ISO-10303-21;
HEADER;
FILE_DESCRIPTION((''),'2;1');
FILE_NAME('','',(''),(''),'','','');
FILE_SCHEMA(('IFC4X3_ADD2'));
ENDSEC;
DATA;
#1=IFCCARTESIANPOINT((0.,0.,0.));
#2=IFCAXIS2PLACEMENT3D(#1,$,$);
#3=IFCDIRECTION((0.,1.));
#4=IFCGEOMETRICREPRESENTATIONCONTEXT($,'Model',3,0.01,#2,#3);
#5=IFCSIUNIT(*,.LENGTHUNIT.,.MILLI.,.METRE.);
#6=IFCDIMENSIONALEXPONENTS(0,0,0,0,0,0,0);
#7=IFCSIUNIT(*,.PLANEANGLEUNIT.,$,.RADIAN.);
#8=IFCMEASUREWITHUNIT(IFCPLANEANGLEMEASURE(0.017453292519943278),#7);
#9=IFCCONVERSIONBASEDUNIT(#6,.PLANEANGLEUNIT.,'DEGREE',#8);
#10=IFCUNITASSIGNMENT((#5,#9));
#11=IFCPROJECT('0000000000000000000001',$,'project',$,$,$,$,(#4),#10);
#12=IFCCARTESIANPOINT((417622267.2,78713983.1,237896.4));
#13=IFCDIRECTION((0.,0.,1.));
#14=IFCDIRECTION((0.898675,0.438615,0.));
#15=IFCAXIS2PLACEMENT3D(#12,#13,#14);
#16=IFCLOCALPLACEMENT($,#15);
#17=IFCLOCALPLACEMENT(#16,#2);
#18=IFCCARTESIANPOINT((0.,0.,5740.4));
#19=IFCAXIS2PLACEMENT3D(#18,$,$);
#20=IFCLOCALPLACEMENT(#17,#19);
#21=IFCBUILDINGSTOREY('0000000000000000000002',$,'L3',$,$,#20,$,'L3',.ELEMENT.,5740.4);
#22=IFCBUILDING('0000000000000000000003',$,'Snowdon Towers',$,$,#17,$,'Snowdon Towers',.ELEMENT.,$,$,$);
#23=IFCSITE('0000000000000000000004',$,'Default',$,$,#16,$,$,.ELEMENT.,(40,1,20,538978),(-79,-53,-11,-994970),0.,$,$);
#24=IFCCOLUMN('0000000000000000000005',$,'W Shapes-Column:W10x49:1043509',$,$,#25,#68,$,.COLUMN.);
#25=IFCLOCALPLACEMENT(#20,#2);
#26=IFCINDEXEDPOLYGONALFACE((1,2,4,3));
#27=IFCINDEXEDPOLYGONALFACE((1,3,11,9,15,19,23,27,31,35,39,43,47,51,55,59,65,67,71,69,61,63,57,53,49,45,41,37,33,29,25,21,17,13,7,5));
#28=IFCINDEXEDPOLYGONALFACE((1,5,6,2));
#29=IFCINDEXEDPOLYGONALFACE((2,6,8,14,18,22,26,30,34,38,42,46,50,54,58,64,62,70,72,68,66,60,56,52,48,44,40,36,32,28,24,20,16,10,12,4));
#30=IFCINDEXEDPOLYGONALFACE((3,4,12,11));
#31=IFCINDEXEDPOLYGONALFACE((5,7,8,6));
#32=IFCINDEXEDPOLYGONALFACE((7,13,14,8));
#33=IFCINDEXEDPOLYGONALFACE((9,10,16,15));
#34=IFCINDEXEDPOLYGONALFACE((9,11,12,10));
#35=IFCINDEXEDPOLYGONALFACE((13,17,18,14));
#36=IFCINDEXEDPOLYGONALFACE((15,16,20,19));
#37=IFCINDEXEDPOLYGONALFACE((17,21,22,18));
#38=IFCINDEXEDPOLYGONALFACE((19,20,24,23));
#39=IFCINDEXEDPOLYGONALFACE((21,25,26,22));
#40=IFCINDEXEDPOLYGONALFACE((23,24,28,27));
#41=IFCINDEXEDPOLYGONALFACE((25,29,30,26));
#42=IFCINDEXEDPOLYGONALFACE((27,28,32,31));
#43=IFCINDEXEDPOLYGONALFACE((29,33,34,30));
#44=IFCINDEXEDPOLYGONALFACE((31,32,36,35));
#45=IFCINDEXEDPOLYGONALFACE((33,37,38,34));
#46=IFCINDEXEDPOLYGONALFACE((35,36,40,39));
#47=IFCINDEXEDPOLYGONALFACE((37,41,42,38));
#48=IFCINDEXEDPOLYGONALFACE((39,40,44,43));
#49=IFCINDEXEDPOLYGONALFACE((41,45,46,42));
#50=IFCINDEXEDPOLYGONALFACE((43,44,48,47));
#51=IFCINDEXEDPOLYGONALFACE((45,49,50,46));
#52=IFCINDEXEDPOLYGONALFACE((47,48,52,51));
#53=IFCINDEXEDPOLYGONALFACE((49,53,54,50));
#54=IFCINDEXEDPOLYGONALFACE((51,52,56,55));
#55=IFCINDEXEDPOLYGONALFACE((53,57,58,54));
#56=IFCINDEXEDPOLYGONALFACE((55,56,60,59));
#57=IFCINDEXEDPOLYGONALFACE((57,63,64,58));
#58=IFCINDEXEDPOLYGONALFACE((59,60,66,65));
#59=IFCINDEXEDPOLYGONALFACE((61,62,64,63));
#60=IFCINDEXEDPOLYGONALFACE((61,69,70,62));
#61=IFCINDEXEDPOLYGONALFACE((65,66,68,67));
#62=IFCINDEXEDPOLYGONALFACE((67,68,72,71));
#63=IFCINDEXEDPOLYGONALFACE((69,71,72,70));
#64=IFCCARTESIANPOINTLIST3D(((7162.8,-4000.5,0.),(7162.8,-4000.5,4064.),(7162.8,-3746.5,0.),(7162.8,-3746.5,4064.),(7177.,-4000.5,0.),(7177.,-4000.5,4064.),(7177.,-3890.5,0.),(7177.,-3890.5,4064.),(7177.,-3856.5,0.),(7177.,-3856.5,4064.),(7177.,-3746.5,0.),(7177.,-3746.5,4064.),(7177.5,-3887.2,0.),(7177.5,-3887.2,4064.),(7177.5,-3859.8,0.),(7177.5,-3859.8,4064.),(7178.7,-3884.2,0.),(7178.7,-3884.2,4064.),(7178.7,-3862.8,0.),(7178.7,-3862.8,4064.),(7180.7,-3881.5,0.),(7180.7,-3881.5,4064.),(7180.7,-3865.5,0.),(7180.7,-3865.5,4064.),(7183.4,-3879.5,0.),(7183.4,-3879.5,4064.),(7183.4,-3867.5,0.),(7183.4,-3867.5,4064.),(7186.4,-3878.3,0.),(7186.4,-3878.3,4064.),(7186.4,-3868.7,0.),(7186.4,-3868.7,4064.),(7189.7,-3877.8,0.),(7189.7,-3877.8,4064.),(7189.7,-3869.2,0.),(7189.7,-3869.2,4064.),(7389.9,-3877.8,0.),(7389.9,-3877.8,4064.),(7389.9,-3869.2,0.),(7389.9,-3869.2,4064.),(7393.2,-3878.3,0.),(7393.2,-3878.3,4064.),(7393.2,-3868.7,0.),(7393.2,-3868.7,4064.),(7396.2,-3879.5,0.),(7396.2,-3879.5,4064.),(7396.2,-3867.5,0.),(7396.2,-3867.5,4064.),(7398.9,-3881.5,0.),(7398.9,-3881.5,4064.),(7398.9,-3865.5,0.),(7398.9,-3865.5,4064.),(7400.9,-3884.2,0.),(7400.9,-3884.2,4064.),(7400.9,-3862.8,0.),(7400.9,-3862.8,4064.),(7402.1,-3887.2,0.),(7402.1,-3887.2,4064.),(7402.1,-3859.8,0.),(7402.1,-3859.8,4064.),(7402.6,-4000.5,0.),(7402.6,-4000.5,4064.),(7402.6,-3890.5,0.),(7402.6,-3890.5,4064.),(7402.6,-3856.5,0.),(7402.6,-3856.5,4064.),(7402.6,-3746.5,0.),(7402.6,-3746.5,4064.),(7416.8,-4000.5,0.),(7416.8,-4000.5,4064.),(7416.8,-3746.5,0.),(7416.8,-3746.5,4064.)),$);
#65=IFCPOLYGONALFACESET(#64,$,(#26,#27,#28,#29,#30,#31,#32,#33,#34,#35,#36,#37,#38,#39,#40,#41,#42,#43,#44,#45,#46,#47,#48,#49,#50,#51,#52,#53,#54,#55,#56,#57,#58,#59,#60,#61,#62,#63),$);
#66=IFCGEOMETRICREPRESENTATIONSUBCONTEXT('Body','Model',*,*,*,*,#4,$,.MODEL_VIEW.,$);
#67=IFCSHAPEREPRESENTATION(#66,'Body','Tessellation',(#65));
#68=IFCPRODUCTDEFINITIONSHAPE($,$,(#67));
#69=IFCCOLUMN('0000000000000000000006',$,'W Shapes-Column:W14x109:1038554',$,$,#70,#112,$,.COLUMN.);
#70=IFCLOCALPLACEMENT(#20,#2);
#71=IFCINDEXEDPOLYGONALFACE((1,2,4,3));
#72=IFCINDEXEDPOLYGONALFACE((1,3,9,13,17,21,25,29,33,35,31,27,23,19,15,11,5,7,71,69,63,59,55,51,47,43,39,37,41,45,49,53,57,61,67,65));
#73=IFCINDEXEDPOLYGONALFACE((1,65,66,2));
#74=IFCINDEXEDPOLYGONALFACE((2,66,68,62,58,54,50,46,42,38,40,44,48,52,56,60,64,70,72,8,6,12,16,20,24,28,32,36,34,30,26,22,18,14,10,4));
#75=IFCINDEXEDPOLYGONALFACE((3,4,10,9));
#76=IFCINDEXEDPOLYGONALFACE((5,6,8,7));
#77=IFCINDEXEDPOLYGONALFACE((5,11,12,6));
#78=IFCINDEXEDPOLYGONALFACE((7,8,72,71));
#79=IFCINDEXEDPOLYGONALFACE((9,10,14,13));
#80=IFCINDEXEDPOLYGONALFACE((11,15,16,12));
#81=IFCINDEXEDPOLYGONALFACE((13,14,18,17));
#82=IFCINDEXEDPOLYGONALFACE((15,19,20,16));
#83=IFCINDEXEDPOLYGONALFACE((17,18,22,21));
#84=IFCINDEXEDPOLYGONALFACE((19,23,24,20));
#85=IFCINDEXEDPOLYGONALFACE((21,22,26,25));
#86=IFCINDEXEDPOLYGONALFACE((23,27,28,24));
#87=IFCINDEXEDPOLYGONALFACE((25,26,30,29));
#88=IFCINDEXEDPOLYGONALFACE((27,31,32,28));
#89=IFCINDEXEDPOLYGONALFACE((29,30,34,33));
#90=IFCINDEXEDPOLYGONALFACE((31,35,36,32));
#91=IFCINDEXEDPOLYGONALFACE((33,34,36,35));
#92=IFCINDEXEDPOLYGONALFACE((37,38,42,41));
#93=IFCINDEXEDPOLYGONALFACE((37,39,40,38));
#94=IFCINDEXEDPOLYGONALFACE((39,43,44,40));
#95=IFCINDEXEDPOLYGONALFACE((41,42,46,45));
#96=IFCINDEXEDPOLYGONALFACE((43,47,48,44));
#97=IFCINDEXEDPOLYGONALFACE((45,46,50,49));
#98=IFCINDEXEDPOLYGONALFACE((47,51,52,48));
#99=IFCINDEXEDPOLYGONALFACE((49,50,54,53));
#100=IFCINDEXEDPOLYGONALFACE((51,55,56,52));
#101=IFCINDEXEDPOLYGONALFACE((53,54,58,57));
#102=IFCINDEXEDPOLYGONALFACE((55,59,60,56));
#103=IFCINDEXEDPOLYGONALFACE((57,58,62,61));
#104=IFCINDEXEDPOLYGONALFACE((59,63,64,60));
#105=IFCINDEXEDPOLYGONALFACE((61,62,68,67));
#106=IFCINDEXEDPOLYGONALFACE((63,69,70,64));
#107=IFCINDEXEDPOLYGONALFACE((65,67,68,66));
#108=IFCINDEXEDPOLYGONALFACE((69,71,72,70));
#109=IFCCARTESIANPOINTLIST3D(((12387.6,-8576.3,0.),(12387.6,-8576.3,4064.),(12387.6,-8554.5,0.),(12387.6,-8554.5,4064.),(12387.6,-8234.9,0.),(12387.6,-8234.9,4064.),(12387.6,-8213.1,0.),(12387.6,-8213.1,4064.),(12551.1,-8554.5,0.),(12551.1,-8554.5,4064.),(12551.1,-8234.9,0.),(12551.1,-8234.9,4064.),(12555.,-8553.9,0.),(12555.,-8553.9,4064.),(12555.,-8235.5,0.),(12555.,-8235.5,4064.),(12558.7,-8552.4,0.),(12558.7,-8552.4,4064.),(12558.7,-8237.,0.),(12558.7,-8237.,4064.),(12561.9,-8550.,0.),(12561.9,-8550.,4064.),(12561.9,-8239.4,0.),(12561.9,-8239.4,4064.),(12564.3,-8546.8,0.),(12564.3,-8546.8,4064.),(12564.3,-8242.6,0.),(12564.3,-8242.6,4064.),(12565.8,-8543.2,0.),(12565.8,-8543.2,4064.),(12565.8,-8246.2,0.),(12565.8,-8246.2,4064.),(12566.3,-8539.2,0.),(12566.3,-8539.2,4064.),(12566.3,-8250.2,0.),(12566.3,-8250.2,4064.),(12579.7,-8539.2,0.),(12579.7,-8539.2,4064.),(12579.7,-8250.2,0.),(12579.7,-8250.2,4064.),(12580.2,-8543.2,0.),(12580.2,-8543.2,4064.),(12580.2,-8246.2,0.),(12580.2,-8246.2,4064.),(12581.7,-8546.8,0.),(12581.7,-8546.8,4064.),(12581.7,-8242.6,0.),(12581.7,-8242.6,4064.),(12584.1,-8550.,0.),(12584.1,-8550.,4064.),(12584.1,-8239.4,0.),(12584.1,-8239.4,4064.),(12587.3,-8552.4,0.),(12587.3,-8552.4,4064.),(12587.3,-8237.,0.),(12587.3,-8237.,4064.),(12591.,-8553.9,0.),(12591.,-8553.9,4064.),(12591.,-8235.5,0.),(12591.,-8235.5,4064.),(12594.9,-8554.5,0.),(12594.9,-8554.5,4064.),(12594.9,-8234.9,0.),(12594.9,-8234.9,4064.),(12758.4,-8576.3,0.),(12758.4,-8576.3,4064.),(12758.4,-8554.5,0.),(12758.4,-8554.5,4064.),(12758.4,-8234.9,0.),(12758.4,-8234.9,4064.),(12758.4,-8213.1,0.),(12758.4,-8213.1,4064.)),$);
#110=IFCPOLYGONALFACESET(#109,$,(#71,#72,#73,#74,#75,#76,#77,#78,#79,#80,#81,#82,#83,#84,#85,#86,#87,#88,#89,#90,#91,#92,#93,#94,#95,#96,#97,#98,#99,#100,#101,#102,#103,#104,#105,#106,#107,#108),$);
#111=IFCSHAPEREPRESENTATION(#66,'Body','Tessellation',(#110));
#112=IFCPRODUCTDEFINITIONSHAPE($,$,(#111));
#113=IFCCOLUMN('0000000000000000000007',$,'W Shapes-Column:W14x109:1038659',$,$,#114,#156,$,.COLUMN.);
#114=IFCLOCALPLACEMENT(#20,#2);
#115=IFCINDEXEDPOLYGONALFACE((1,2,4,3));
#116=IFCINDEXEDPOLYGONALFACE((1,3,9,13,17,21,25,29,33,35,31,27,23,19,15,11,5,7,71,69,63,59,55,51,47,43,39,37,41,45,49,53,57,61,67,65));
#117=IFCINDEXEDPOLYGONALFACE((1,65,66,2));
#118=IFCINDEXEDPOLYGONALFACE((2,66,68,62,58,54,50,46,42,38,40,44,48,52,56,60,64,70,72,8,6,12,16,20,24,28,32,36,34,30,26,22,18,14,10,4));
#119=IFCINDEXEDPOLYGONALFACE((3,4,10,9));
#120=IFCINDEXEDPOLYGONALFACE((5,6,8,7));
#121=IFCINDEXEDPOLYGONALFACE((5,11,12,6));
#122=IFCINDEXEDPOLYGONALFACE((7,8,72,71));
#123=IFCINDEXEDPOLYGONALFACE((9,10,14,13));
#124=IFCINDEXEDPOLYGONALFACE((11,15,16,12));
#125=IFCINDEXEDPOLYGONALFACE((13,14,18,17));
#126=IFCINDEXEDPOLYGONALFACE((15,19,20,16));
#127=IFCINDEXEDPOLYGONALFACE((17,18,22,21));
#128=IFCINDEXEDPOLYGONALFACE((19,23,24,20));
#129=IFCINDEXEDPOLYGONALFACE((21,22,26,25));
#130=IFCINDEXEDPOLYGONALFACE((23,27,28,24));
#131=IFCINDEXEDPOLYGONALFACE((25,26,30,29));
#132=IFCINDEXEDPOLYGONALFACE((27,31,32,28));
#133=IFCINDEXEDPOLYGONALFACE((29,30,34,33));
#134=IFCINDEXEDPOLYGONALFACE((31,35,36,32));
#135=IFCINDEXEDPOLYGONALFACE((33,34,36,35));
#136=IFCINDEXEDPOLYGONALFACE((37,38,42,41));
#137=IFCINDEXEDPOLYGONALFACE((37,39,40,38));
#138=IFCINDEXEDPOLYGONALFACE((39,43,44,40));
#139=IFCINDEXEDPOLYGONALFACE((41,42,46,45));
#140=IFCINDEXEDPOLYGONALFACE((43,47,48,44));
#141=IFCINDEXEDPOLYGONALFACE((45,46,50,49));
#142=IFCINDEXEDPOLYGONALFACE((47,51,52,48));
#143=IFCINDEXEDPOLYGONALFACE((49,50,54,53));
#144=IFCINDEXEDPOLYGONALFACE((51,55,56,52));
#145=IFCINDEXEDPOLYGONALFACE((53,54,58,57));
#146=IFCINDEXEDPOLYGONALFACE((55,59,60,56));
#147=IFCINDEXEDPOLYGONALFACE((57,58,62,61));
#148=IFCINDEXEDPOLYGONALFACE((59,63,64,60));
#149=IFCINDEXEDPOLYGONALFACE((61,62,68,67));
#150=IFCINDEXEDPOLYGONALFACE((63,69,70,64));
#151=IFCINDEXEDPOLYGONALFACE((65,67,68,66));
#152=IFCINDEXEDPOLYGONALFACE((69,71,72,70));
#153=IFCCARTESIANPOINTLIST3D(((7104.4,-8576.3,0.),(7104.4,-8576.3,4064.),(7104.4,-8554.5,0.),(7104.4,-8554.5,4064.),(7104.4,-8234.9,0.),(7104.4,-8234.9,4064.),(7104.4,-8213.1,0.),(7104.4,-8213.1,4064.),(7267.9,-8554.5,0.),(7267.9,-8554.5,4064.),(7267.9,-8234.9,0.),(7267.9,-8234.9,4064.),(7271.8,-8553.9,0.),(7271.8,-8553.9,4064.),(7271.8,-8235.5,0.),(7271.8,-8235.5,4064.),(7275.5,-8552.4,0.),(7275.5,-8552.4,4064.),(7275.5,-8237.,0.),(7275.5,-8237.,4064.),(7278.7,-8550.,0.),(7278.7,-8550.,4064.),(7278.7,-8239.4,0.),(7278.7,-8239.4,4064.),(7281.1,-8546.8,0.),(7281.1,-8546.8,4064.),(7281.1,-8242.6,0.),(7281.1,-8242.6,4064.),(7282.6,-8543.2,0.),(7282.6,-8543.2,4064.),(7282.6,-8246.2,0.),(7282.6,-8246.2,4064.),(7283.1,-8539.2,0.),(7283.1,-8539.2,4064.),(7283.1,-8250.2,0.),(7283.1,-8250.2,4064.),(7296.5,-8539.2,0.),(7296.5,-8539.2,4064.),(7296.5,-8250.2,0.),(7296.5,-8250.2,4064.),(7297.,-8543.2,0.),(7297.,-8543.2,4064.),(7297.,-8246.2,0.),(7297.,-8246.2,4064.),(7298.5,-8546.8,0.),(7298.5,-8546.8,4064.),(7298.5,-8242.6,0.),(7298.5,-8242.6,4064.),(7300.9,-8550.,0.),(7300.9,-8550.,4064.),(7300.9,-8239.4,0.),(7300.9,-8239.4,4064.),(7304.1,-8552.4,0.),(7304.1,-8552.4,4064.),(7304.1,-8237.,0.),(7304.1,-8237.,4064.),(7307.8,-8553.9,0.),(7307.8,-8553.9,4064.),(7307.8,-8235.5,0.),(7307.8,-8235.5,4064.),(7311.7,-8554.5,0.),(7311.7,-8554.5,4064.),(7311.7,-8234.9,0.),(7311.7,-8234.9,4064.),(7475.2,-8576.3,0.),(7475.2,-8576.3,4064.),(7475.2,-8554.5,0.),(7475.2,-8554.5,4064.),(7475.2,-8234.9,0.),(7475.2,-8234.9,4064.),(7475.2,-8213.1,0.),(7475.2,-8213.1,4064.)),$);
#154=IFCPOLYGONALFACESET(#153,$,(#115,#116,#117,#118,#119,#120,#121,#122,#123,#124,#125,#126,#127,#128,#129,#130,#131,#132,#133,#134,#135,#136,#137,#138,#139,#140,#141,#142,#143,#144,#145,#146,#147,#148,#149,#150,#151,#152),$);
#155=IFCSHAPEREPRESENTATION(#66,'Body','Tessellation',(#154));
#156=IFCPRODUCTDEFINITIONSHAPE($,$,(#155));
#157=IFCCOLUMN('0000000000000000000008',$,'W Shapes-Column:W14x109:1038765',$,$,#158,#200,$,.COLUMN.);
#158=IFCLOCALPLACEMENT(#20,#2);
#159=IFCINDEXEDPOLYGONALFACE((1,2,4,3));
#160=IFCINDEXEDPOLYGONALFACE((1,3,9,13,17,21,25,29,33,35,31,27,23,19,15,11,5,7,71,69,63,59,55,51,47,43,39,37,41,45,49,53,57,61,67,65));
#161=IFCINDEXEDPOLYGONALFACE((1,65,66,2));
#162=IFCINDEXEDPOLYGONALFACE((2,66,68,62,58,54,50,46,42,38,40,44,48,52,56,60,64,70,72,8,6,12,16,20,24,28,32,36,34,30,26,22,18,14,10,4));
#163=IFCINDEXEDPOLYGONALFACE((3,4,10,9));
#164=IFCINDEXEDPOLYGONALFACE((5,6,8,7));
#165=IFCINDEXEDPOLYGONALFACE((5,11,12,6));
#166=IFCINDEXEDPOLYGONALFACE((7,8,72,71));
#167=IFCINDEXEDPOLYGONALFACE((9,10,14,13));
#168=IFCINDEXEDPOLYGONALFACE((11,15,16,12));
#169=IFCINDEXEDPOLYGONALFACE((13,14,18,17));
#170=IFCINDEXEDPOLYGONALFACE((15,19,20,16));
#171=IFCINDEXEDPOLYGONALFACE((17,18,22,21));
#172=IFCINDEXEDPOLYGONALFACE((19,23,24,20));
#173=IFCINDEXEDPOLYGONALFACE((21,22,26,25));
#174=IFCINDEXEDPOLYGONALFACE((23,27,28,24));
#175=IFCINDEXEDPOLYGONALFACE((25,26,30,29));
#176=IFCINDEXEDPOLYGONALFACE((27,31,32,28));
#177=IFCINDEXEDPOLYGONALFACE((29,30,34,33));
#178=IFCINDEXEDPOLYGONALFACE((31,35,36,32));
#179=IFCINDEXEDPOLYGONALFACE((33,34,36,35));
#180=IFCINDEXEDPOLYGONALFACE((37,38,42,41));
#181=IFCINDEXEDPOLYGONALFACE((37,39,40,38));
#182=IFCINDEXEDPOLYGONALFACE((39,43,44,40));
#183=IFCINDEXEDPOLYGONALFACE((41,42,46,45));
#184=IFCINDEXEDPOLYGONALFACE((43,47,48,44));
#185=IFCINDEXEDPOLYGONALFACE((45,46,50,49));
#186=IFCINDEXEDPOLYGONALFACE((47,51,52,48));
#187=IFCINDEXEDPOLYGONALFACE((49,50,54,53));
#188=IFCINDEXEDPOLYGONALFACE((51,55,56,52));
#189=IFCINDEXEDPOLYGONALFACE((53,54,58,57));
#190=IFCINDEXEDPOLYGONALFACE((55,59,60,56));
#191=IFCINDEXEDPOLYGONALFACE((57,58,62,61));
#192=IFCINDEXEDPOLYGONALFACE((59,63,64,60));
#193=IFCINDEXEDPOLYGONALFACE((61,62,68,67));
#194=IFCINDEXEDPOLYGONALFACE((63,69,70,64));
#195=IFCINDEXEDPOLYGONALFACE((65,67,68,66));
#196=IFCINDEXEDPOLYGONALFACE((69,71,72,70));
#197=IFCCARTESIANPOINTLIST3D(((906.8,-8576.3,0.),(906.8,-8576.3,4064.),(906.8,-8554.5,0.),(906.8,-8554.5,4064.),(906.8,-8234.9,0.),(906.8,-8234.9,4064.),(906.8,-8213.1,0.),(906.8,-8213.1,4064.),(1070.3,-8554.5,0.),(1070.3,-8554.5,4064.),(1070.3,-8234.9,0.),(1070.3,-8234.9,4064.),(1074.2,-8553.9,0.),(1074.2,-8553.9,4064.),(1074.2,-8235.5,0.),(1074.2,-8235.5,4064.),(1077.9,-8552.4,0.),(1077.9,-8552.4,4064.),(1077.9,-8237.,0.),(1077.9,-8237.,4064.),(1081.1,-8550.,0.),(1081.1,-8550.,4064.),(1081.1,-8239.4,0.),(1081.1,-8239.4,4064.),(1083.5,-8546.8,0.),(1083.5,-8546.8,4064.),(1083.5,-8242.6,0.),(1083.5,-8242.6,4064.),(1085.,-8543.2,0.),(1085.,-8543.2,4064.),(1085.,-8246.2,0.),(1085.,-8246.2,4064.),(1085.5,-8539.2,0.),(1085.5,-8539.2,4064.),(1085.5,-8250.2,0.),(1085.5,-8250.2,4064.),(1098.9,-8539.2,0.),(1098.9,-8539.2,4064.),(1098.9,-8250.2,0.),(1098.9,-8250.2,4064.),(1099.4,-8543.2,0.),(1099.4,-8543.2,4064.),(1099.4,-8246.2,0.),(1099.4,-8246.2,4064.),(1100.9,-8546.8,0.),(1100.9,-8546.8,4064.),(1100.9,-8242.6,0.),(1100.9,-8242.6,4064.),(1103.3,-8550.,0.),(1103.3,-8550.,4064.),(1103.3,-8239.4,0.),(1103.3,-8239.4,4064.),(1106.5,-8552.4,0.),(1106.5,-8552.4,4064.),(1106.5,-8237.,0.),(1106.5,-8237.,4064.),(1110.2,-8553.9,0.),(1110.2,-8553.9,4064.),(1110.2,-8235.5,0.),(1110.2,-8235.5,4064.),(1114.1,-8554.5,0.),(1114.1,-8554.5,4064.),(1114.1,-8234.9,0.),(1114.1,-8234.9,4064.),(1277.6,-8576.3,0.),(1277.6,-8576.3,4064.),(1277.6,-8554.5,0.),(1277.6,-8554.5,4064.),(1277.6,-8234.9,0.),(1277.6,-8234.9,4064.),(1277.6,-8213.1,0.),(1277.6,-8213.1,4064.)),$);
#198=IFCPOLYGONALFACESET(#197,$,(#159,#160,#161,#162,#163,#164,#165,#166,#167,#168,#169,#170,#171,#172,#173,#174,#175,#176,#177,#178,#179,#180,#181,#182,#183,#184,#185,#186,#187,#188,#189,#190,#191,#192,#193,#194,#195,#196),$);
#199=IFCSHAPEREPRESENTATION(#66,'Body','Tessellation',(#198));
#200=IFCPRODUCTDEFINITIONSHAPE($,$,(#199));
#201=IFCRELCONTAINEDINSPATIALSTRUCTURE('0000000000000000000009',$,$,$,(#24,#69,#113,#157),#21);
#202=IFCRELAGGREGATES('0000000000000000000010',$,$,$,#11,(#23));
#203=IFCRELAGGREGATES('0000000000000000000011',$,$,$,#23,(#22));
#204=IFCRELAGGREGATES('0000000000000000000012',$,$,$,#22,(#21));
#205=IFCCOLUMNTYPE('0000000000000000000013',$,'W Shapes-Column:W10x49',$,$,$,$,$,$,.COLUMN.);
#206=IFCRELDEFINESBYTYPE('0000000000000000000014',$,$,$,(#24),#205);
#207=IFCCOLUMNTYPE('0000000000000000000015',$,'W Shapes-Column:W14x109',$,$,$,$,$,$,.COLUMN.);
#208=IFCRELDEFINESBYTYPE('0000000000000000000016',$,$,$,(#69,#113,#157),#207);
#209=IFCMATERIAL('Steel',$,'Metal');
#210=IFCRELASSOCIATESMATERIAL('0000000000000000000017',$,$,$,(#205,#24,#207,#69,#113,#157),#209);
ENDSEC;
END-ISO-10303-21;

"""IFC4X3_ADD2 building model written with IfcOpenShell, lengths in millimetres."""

from ifc_helpers import new_model, entity, si_unit, converted_unit, direction, frame, frame_2d, origin, place, context, subcontext, project, spatial, i_section, extrude, source, transform, mapped, material, material_profile, profile_set, profile_usage, type_object, type_shapes, element, save


model = new_model("IFC4X3_ADD2")

# Units and contexts
model_context = context("Model", 3, precision=0.01, world=origin(), true_north=direction((0.0, 1.0)))
body_context = subcontext(model_context, "Body", "Model", "MODEL_VIEW")
ifc_project = project(units=[si_unit("LENGTHUNIT", "METRE", prefix="MILLI"), converted_unit("PLANEANGLEUNIT", "DEGREE", entity("IfcPlaneAngleMeasure", 0.017453292519943278), si_unit("PLANEANGLEUNIT", "RADIAN"), dimensions=[0, 0, 0, 0, 0, 0, 0])], contexts=[model_context])

# Site, building, storey
site_placement = place(None, frame((417622267.2, 78713983.1, 237896.4), z_axis=(0.0, 0.0, 1.0), x_axis=(0.898675, 0.438615, 0.0)))
site = spatial("IfcSite", under=ifc_project, at=site_placement, Name="Default", CompositionType="ELEMENT", RefLatitude=(40, 1, 20, 538978), RefLongitude=(-79, -53, -11, -994970), RefElevation=0.0)
building_placement = place(site_placement, origin())
building = spatial("IfcBuilding", under=site, at=building_placement, Name="Snowdon Towers", LongName="Snowdon Towers", CompositionType="ELEMENT")
storey_placement = place(building_placement, frame((0.0, 0.0, 5740.4)))
storey = spatial("IfcBuildingStorey", under=building, at=storey_placement, Name="L3", LongName="L3", CompositionType="ELEMENT", Elevation=5740.4)

# Columns
ifc_material_1 = material(Name="Steel", Category="Metal")
ifc_material_profile_1 = material_profile(ifc_material_1, i_section(OverallWidth=254.0, OverallDepth=254.0, WebThickness=8.6, FlangeThickness=14.2, FilletRadius=12.7, at=frame_2d((0.0, 0.0), x_axis=(1.0, 0.0))), Name="W10x49")
ifc_profile_set_1 = profile_set([ifc_material_profile_1], Name="W10x49")
ifc_profile_usage_1 = profile_usage(ifc_profile_set_1)
column_type_1 = type_object("IfcColumnType", Name="W Shapes-Column:W10x49", PredefinedType="COLUMN", material=ifc_profile_set_1)
shared_shape_1 = source(origin(), body_context, "Body", "SweptSolid", [
    extrude(i_section(OverallWidth=254.0, OverallDepth=254.0, WebThickness=8.6, FlangeThickness=14.2, FilletRadius=12.7, at=frame_2d((0.0, 0.0), x_axis=(1.0, 0.0))), frame((0.0, 0.0, 5740.4), z_axis=(0.0, 0.0, 1.0), x_axis=(-1.0, 0.0, 0.0)), (0.0, 0.0, 1.0), 4064.0),
])
type_shapes(column_type_1, [shared_shape_1])
for number, where, z_axis, x_axis, name in (
    (1, (7289.8, -3873.5, -5740.4), (0.0, 0.0, 1.0), (0.0, 1.0, 0.0), "W Shapes-Column:W10x49:1043509"),
):
    element("IfcColumn", number, at=place(storey_placement, frame(where, z_axis=z_axis, x_axis=x_axis)), inside=storey, type_object=column_type_1, material=ifc_profile_usage_1, Name=name, PredefinedType="COLUMN", context=body_context, shape_type="MappedRepresentation", body=[
        mapped(shared_shape_1, transform((0.0, 0.0, 0.0), scale=1.0)),
    ])
ifc_material_profile_2 = material_profile(ifc_material_1, i_section(OverallWidth=370.8, OverallDepth=363.2, WebThickness=13.3, FlangeThickness=21.8, FilletRadius=15.2, at=frame_2d((0.0, 0.0), x_axis=(1.0, 0.0))), Name="W14x109")
ifc_profile_set_2 = profile_set([ifc_material_profile_2], Name="W14x109")
ifc_profile_usage_2 = profile_usage(ifc_profile_set_2)
column_type_2 = type_object("IfcColumnType", Name="W Shapes-Column:W14x109", PredefinedType="COLUMN", material=ifc_profile_set_2)
shared_shape_2 = source(origin(), body_context, "Body", "SweptSolid", [
    extrude(i_section(OverallWidth=370.8, OverallDepth=363.2, WebThickness=13.3, FlangeThickness=21.8, FilletRadius=15.2, at=frame_2d((0.0, 0.0), x_axis=(1.0, 0.0))), frame((0.0, 0.0, 5740.4), z_axis=(0.0, 0.0, 1.0), x_axis=(-1.0, 0.0, 0.0)), (0.0, 0.0, 1.0), 4064.0),
])
type_shapes(column_type_2, [shared_shape_2])
for number, where, z_axis, x_axis, name in (
    (2, (12573.0, -8394.7, -5740.4), (0.0, 0.0, 1.0), (-1.0, 0.0, 0.0), "W Shapes-Column:W14x109:1038554"),
    (3, (7289.8, -8394.7, -5740.4), (0.0, 0.0, 1.0), (-1.0, 0.0, 0.0), "W Shapes-Column:W14x109:1038659"),
    (4, (1092.2, -8394.7, -5740.4), (0.0, 0.0, 1.0), (-1.0, 0.0, 0.0), "W Shapes-Column:W14x109:1038765"),
):
    element("IfcColumn", number, at=place(storey_placement, frame(where, z_axis=z_axis, x_axis=x_axis)), inside=storey, type_object=column_type_2, material=ifc_profile_usage_2, Name=name, PredefinedType="COLUMN", context=body_context, shape_type="MappedRepresentation", body=[
        mapped(shared_shape_2, transform((0.0, 0.0, 0.0), scale=1.0)),
    ])

save(model, "model.ifc")
